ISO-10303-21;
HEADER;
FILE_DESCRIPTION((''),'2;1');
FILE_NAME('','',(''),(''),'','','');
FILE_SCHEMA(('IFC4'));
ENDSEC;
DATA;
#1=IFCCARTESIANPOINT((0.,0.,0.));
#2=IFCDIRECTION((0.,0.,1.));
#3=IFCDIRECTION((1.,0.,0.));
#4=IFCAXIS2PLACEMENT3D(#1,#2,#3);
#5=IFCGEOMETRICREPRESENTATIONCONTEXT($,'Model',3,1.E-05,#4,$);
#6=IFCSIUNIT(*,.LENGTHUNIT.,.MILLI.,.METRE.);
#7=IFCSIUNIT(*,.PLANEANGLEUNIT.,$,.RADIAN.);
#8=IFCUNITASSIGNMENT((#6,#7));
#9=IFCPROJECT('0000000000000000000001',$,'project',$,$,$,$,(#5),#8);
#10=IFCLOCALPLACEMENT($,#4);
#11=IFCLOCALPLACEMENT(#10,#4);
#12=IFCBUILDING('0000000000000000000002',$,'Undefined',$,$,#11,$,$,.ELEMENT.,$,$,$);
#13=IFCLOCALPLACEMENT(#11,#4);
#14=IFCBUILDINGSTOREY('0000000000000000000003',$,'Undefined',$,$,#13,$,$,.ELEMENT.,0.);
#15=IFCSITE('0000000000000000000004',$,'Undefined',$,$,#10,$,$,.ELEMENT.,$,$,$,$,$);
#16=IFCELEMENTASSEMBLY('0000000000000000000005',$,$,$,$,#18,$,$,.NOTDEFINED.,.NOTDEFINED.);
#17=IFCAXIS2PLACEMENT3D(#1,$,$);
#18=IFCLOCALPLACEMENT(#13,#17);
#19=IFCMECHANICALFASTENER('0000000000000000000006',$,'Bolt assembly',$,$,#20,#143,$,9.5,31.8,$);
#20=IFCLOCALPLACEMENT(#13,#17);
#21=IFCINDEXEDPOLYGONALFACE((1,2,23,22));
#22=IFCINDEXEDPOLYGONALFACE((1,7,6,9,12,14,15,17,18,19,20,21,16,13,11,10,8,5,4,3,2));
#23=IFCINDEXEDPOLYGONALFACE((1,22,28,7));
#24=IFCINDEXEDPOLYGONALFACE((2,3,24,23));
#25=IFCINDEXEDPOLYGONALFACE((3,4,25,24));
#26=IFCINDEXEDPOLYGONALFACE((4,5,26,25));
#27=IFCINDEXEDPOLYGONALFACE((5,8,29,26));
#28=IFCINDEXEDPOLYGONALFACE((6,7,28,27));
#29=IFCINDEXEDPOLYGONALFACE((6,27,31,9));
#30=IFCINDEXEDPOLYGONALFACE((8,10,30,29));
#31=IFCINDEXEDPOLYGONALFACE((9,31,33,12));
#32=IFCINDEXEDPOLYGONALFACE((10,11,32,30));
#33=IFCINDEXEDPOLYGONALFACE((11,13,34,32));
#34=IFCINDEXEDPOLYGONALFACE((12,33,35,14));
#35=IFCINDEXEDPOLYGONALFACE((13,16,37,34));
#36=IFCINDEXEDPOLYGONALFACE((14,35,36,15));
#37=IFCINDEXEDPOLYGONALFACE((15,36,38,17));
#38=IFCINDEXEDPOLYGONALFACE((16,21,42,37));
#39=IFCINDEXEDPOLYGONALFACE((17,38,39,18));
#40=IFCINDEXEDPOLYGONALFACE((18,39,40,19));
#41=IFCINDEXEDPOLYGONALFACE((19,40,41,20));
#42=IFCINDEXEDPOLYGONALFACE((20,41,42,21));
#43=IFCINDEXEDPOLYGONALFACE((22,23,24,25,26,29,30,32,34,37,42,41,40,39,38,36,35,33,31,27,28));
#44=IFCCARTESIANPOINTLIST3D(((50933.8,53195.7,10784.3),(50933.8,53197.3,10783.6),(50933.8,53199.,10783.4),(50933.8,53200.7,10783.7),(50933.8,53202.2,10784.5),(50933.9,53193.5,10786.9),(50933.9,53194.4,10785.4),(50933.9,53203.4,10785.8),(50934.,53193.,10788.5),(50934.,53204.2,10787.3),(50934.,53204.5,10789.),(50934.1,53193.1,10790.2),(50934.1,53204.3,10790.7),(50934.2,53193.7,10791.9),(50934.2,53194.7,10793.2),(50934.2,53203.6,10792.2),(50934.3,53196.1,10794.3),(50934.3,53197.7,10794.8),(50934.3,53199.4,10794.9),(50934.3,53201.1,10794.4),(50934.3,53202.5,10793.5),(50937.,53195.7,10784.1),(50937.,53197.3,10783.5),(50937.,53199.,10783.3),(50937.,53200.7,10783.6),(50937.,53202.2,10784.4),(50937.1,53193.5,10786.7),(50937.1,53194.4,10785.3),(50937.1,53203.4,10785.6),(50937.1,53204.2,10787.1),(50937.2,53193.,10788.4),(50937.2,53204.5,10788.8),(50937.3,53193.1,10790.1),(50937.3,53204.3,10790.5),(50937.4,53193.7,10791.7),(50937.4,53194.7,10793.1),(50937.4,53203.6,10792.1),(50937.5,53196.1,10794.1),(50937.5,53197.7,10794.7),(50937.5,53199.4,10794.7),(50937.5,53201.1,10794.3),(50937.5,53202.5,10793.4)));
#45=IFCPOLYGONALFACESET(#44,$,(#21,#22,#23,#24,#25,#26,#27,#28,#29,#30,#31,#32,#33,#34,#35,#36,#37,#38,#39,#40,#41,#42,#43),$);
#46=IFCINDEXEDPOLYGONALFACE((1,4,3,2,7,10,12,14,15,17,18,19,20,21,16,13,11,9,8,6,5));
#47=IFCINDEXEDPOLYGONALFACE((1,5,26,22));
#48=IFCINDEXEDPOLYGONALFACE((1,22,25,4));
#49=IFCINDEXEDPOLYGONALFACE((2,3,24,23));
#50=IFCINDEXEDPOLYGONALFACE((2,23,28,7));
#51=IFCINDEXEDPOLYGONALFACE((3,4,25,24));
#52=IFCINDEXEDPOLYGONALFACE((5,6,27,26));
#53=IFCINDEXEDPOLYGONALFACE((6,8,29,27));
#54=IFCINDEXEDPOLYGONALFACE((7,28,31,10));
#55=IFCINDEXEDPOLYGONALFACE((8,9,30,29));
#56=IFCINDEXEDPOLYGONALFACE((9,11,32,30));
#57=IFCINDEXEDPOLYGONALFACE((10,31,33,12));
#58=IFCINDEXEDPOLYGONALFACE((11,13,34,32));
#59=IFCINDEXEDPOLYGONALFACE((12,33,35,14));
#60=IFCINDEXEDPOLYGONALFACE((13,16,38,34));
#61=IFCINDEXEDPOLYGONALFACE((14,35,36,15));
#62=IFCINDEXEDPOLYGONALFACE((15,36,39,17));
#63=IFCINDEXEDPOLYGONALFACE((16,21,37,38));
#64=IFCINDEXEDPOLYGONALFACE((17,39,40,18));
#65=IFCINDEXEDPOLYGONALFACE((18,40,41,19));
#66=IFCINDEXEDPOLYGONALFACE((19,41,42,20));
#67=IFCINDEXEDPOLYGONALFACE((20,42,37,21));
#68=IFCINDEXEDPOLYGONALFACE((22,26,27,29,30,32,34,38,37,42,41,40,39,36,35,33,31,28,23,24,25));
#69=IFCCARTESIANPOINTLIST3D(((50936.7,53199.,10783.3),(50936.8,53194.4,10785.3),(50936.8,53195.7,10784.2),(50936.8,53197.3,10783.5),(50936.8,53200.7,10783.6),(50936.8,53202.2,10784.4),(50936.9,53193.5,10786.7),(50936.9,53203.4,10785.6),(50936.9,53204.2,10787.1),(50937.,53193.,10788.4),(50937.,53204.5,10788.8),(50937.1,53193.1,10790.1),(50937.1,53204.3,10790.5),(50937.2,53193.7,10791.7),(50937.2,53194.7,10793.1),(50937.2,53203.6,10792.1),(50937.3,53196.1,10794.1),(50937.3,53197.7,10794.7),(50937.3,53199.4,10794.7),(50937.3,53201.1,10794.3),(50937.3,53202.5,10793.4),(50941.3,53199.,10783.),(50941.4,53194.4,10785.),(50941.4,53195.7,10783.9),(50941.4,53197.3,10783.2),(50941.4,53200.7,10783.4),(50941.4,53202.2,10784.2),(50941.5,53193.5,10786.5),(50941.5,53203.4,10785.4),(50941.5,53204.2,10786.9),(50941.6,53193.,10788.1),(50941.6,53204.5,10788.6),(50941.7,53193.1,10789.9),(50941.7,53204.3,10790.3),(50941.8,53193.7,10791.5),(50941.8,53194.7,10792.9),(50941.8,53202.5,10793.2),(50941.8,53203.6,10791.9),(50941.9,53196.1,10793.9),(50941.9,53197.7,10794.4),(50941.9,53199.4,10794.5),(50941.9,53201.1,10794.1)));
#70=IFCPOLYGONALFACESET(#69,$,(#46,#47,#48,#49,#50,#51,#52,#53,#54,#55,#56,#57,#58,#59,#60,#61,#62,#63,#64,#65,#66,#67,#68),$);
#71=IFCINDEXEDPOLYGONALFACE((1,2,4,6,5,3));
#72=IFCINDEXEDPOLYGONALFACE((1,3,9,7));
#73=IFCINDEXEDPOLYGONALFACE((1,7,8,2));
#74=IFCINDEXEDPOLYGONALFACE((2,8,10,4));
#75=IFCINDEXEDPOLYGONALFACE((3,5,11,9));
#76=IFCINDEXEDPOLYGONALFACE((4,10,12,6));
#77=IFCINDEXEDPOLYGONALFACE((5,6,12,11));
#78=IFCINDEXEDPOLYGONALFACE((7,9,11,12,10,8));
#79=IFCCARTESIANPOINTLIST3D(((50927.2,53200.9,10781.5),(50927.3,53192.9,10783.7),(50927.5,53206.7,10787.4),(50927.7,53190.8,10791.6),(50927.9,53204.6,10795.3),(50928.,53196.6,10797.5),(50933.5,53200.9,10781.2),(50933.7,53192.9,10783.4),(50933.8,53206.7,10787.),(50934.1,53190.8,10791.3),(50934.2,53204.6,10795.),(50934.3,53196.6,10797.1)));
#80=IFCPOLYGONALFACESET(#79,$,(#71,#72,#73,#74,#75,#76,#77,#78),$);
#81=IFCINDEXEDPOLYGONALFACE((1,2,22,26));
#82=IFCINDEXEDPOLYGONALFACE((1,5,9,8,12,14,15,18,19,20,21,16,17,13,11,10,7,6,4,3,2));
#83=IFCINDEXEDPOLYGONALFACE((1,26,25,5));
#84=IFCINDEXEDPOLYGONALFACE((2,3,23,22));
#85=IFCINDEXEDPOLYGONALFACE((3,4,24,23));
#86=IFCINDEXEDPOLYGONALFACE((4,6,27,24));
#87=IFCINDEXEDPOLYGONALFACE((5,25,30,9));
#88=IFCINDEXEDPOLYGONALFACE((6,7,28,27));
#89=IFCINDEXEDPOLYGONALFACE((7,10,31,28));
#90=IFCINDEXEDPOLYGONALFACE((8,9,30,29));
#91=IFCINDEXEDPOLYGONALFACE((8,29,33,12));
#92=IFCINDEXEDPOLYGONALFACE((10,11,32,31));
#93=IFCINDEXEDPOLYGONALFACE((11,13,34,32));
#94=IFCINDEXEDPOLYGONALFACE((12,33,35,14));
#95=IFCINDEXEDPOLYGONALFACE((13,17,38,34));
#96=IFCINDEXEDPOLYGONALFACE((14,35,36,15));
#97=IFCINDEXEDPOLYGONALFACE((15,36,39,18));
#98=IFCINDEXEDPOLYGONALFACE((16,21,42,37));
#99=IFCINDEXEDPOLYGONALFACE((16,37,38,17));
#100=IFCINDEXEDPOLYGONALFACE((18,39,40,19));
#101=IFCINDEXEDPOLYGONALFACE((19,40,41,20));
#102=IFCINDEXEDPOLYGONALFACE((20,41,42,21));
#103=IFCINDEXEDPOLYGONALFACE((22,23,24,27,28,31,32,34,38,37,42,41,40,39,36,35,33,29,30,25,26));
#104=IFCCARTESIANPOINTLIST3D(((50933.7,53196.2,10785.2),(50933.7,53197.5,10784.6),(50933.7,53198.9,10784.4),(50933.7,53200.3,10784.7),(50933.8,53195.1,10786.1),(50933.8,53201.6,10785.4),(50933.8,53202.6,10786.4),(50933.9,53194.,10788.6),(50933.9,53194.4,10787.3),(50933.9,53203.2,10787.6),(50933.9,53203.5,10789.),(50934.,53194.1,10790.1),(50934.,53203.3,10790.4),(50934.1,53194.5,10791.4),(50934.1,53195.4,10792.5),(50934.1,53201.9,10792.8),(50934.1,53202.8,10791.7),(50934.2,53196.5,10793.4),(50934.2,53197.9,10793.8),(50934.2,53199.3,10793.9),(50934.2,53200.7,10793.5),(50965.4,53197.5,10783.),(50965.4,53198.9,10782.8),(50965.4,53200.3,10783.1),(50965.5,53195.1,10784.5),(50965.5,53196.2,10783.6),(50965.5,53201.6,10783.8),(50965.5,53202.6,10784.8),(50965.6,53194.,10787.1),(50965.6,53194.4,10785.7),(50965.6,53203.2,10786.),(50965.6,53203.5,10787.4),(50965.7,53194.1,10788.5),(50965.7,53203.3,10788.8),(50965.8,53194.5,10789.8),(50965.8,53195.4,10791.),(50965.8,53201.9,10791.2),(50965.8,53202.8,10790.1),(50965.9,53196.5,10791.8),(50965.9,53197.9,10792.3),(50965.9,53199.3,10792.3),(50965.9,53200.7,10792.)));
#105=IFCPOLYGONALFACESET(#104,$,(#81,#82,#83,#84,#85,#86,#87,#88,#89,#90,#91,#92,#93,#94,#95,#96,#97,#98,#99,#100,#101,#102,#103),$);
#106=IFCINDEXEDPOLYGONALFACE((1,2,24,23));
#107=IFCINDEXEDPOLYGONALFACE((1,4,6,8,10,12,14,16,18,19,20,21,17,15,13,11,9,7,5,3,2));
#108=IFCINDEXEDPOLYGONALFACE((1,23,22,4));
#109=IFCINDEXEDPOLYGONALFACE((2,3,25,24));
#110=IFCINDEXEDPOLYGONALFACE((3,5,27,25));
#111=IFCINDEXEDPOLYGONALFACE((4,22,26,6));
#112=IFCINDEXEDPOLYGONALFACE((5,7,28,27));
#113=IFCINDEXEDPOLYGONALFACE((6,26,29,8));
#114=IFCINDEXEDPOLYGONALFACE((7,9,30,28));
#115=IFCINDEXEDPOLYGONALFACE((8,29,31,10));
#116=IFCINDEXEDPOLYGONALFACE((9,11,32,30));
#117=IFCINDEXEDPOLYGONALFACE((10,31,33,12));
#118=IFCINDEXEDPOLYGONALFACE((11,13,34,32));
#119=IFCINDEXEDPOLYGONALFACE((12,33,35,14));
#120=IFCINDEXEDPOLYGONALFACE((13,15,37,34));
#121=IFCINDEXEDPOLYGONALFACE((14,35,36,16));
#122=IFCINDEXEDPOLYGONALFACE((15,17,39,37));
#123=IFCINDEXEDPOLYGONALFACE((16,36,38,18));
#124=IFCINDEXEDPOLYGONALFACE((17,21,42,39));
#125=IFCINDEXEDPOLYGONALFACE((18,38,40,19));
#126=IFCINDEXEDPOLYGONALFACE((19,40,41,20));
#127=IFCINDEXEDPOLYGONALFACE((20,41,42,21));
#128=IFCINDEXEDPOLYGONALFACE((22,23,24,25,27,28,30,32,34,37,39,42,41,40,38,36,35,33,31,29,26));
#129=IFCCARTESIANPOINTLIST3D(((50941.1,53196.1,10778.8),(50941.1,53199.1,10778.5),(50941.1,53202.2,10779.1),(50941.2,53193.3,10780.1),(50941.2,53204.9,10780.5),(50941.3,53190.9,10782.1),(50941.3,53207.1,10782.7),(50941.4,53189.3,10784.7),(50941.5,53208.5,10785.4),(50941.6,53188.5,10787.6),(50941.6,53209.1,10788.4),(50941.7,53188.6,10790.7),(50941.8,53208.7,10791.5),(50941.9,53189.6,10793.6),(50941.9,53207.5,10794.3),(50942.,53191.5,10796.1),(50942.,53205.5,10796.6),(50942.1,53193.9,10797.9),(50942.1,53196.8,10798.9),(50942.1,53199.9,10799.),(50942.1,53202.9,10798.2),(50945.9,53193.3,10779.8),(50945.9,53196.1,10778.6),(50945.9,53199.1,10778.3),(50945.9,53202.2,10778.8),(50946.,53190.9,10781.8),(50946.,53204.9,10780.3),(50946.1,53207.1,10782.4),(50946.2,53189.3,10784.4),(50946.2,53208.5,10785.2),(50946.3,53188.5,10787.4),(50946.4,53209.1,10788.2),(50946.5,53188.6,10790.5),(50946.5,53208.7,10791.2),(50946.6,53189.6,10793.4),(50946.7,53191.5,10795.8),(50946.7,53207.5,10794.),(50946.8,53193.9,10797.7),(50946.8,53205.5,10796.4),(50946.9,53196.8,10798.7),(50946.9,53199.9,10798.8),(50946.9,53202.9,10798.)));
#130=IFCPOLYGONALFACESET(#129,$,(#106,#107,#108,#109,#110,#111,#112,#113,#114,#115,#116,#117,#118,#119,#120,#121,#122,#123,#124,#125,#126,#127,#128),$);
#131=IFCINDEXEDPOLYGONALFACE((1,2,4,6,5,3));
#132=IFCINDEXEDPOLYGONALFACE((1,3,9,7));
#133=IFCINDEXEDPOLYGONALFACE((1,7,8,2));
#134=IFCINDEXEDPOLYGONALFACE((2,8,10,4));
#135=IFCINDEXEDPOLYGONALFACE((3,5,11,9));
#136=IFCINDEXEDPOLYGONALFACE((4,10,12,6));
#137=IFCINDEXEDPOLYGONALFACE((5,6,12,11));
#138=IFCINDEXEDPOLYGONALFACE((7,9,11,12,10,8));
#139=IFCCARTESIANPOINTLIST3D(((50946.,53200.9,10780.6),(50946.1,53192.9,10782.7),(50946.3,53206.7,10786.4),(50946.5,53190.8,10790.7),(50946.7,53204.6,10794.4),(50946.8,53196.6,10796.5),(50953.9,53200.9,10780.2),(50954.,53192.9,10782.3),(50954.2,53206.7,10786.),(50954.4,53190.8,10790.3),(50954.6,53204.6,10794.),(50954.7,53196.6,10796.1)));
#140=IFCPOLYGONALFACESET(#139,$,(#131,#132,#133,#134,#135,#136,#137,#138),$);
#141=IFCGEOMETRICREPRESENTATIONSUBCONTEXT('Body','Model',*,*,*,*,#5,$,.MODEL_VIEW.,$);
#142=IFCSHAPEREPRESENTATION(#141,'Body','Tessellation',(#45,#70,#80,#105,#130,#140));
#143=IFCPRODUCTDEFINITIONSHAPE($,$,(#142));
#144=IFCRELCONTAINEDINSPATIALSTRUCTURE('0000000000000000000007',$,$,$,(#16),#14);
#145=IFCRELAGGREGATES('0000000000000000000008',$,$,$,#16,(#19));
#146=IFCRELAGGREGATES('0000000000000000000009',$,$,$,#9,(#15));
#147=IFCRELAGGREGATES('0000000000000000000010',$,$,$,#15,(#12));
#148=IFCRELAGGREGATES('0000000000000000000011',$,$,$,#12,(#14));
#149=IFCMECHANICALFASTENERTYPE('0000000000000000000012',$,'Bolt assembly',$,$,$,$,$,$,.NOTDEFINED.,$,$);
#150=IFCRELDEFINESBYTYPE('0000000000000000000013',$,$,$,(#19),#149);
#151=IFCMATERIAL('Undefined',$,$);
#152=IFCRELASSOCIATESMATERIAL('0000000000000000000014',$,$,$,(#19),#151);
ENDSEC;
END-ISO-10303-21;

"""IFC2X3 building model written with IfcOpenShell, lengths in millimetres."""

from ifc_helpers import new_model, si_unit, frame, origin_with_axes, origin_2d_with_axis, place, context, subcontext, project, spatial, polyline, circle, outline, extrude, source, transform, mapped, material, type_object, element, aggregate, save


model = new_model("IFC2X3")

# Units and contexts
model_context = context("Model", 3, precision=1e-05, world=origin_with_axes())
body_context = subcontext(model_context, "Body", "Model", "MODEL_VIEW")
ifc_project = project(units=[si_unit("LENGTHUNIT", "METRE", prefix="MILLI"), si_unit("PLANEANGLEUNIT", "RADIAN")], contexts=[model_context])

# Site, building, storey
site_placement = place(None, origin_with_axes())
site = spatial("IfcSite", under=ifc_project, at=site_placement, Name="Undefined", CompositionType="ELEMENT")
building_placement = place(site_placement, origin_with_axes())
building = spatial("IfcBuilding", under=site, at=building_placement, Name="Undefined", CompositionType="ELEMENT")
storey_placement = place(building_placement, origin_with_axes())
storey = spatial("IfcBuildingStorey", under=building, at=storey_placement, Name="Undefined", CompositionType="ELEMENT", Elevation=0.0)

# Element assembly
assembly_1_placement = place(storey_placement, origin_with_axes())
assembly_1 = element("IfcElementAssembly", 1, at=assembly_1_placement, inside=storey, AssemblyPlace="NOTDEFINED", PredefinedType="NOTDEFINED")

# Shared definitions
ifc_material_1 = material(Name="Undefined")
mechanical_fastener_type = type_object("IfcMechanicalFastenerType", Name="Bolt assembly")

# Mechanical fastener
shared_shape_1 = source(origin_with_axes(), body_context, "Body", "SweptSolid", [
    extrude(circle(Radius=5.8, at=origin_2d_with_axis()), frame((0.0, -7.6, 0.0), z_axis=(0.0, 1.0, 0.0), x_axis=(1.0, 0.0, 0.0)), (0.0, 0.0, 1.0), 3.2),
    extrude(circle(Radius=5.8, at=origin_2d_with_axis()), frame((0.0, -4.6, 0.0), z_axis=(0.0, 1.0, 0.0), x_axis=(1.0, 0.0, 0.0)), (0.0, 0.0, 1.0), 4.6),
    extrude(outline(polyline([(7.1, -4.1), (7.1, 4.1), (0.0, 8.2), (-7.1, 4.1), (-7.1, -4.1), (0.0, -8.2), (7.1, -4.1)])), frame((0.0, -14.0, 0.0), z_axis=(0.0, 1.0, 0.0), x_axis=(1.0, 0.0, 0.0)), (0.0, 0.0, 1.0), 6.3),
    extrude(circle(Radius=4.8, at=origin_2d_with_axis()), frame((0.0, -7.7, 0.0), z_axis=(0.0, 1.0, 0.0), x_axis=(1.0, 0.0, 0.0)), (0.0, 0.0, 1.0), 31.8),
    extrude(circle(Radius=10.3, at=origin_2d_with_axis()), frame((0.0, 0.0, 0.0), z_axis=(0.0, 1.0, 0.0), x_axis=(1.0, 0.0, 0.0)), (0.0, 0.0, 1.0), 4.8),
    extrude(outline(polyline([(7.1, -4.1), (7.1, 4.1), (0.0, 8.2), (-7.1, 4.1), (-7.1, -4.1), (0.0, -8.2), (7.1, -4.1)])), frame((0.0, 4.8, 0.0), z_axis=(0.0, 1.0, 0.0), x_axis=(1.0, 0.0, 0.0)), (0.0, 0.0, 1.0), 7.9),
])
mechanical_fastener_1_placement = place(assembly_1_placement, frame((50941.6, 53198.8, 10788.8), z_axis=(0.035281, 0.707107, 0.706226), x_axis=(0.035282, -0.707107, 0.706226)))
mechanical_fastener_1 = element("IfcMechanicalFastener", 2, at=mechanical_fastener_1_placement, type_object=mechanical_fastener_type, material=ifc_material_1, Name="Bolt assembly", NominalDiameter=9.5, NominalLength=31.8, context=body_context, shape_type="MappedRepresentation", body=[
    mapped(shared_shape_1, transform((0.0, 0.0, 0.0))),
])
aggregate(assembly_1, [mechanical_fastener_1])

save(model, "model.ifc")
